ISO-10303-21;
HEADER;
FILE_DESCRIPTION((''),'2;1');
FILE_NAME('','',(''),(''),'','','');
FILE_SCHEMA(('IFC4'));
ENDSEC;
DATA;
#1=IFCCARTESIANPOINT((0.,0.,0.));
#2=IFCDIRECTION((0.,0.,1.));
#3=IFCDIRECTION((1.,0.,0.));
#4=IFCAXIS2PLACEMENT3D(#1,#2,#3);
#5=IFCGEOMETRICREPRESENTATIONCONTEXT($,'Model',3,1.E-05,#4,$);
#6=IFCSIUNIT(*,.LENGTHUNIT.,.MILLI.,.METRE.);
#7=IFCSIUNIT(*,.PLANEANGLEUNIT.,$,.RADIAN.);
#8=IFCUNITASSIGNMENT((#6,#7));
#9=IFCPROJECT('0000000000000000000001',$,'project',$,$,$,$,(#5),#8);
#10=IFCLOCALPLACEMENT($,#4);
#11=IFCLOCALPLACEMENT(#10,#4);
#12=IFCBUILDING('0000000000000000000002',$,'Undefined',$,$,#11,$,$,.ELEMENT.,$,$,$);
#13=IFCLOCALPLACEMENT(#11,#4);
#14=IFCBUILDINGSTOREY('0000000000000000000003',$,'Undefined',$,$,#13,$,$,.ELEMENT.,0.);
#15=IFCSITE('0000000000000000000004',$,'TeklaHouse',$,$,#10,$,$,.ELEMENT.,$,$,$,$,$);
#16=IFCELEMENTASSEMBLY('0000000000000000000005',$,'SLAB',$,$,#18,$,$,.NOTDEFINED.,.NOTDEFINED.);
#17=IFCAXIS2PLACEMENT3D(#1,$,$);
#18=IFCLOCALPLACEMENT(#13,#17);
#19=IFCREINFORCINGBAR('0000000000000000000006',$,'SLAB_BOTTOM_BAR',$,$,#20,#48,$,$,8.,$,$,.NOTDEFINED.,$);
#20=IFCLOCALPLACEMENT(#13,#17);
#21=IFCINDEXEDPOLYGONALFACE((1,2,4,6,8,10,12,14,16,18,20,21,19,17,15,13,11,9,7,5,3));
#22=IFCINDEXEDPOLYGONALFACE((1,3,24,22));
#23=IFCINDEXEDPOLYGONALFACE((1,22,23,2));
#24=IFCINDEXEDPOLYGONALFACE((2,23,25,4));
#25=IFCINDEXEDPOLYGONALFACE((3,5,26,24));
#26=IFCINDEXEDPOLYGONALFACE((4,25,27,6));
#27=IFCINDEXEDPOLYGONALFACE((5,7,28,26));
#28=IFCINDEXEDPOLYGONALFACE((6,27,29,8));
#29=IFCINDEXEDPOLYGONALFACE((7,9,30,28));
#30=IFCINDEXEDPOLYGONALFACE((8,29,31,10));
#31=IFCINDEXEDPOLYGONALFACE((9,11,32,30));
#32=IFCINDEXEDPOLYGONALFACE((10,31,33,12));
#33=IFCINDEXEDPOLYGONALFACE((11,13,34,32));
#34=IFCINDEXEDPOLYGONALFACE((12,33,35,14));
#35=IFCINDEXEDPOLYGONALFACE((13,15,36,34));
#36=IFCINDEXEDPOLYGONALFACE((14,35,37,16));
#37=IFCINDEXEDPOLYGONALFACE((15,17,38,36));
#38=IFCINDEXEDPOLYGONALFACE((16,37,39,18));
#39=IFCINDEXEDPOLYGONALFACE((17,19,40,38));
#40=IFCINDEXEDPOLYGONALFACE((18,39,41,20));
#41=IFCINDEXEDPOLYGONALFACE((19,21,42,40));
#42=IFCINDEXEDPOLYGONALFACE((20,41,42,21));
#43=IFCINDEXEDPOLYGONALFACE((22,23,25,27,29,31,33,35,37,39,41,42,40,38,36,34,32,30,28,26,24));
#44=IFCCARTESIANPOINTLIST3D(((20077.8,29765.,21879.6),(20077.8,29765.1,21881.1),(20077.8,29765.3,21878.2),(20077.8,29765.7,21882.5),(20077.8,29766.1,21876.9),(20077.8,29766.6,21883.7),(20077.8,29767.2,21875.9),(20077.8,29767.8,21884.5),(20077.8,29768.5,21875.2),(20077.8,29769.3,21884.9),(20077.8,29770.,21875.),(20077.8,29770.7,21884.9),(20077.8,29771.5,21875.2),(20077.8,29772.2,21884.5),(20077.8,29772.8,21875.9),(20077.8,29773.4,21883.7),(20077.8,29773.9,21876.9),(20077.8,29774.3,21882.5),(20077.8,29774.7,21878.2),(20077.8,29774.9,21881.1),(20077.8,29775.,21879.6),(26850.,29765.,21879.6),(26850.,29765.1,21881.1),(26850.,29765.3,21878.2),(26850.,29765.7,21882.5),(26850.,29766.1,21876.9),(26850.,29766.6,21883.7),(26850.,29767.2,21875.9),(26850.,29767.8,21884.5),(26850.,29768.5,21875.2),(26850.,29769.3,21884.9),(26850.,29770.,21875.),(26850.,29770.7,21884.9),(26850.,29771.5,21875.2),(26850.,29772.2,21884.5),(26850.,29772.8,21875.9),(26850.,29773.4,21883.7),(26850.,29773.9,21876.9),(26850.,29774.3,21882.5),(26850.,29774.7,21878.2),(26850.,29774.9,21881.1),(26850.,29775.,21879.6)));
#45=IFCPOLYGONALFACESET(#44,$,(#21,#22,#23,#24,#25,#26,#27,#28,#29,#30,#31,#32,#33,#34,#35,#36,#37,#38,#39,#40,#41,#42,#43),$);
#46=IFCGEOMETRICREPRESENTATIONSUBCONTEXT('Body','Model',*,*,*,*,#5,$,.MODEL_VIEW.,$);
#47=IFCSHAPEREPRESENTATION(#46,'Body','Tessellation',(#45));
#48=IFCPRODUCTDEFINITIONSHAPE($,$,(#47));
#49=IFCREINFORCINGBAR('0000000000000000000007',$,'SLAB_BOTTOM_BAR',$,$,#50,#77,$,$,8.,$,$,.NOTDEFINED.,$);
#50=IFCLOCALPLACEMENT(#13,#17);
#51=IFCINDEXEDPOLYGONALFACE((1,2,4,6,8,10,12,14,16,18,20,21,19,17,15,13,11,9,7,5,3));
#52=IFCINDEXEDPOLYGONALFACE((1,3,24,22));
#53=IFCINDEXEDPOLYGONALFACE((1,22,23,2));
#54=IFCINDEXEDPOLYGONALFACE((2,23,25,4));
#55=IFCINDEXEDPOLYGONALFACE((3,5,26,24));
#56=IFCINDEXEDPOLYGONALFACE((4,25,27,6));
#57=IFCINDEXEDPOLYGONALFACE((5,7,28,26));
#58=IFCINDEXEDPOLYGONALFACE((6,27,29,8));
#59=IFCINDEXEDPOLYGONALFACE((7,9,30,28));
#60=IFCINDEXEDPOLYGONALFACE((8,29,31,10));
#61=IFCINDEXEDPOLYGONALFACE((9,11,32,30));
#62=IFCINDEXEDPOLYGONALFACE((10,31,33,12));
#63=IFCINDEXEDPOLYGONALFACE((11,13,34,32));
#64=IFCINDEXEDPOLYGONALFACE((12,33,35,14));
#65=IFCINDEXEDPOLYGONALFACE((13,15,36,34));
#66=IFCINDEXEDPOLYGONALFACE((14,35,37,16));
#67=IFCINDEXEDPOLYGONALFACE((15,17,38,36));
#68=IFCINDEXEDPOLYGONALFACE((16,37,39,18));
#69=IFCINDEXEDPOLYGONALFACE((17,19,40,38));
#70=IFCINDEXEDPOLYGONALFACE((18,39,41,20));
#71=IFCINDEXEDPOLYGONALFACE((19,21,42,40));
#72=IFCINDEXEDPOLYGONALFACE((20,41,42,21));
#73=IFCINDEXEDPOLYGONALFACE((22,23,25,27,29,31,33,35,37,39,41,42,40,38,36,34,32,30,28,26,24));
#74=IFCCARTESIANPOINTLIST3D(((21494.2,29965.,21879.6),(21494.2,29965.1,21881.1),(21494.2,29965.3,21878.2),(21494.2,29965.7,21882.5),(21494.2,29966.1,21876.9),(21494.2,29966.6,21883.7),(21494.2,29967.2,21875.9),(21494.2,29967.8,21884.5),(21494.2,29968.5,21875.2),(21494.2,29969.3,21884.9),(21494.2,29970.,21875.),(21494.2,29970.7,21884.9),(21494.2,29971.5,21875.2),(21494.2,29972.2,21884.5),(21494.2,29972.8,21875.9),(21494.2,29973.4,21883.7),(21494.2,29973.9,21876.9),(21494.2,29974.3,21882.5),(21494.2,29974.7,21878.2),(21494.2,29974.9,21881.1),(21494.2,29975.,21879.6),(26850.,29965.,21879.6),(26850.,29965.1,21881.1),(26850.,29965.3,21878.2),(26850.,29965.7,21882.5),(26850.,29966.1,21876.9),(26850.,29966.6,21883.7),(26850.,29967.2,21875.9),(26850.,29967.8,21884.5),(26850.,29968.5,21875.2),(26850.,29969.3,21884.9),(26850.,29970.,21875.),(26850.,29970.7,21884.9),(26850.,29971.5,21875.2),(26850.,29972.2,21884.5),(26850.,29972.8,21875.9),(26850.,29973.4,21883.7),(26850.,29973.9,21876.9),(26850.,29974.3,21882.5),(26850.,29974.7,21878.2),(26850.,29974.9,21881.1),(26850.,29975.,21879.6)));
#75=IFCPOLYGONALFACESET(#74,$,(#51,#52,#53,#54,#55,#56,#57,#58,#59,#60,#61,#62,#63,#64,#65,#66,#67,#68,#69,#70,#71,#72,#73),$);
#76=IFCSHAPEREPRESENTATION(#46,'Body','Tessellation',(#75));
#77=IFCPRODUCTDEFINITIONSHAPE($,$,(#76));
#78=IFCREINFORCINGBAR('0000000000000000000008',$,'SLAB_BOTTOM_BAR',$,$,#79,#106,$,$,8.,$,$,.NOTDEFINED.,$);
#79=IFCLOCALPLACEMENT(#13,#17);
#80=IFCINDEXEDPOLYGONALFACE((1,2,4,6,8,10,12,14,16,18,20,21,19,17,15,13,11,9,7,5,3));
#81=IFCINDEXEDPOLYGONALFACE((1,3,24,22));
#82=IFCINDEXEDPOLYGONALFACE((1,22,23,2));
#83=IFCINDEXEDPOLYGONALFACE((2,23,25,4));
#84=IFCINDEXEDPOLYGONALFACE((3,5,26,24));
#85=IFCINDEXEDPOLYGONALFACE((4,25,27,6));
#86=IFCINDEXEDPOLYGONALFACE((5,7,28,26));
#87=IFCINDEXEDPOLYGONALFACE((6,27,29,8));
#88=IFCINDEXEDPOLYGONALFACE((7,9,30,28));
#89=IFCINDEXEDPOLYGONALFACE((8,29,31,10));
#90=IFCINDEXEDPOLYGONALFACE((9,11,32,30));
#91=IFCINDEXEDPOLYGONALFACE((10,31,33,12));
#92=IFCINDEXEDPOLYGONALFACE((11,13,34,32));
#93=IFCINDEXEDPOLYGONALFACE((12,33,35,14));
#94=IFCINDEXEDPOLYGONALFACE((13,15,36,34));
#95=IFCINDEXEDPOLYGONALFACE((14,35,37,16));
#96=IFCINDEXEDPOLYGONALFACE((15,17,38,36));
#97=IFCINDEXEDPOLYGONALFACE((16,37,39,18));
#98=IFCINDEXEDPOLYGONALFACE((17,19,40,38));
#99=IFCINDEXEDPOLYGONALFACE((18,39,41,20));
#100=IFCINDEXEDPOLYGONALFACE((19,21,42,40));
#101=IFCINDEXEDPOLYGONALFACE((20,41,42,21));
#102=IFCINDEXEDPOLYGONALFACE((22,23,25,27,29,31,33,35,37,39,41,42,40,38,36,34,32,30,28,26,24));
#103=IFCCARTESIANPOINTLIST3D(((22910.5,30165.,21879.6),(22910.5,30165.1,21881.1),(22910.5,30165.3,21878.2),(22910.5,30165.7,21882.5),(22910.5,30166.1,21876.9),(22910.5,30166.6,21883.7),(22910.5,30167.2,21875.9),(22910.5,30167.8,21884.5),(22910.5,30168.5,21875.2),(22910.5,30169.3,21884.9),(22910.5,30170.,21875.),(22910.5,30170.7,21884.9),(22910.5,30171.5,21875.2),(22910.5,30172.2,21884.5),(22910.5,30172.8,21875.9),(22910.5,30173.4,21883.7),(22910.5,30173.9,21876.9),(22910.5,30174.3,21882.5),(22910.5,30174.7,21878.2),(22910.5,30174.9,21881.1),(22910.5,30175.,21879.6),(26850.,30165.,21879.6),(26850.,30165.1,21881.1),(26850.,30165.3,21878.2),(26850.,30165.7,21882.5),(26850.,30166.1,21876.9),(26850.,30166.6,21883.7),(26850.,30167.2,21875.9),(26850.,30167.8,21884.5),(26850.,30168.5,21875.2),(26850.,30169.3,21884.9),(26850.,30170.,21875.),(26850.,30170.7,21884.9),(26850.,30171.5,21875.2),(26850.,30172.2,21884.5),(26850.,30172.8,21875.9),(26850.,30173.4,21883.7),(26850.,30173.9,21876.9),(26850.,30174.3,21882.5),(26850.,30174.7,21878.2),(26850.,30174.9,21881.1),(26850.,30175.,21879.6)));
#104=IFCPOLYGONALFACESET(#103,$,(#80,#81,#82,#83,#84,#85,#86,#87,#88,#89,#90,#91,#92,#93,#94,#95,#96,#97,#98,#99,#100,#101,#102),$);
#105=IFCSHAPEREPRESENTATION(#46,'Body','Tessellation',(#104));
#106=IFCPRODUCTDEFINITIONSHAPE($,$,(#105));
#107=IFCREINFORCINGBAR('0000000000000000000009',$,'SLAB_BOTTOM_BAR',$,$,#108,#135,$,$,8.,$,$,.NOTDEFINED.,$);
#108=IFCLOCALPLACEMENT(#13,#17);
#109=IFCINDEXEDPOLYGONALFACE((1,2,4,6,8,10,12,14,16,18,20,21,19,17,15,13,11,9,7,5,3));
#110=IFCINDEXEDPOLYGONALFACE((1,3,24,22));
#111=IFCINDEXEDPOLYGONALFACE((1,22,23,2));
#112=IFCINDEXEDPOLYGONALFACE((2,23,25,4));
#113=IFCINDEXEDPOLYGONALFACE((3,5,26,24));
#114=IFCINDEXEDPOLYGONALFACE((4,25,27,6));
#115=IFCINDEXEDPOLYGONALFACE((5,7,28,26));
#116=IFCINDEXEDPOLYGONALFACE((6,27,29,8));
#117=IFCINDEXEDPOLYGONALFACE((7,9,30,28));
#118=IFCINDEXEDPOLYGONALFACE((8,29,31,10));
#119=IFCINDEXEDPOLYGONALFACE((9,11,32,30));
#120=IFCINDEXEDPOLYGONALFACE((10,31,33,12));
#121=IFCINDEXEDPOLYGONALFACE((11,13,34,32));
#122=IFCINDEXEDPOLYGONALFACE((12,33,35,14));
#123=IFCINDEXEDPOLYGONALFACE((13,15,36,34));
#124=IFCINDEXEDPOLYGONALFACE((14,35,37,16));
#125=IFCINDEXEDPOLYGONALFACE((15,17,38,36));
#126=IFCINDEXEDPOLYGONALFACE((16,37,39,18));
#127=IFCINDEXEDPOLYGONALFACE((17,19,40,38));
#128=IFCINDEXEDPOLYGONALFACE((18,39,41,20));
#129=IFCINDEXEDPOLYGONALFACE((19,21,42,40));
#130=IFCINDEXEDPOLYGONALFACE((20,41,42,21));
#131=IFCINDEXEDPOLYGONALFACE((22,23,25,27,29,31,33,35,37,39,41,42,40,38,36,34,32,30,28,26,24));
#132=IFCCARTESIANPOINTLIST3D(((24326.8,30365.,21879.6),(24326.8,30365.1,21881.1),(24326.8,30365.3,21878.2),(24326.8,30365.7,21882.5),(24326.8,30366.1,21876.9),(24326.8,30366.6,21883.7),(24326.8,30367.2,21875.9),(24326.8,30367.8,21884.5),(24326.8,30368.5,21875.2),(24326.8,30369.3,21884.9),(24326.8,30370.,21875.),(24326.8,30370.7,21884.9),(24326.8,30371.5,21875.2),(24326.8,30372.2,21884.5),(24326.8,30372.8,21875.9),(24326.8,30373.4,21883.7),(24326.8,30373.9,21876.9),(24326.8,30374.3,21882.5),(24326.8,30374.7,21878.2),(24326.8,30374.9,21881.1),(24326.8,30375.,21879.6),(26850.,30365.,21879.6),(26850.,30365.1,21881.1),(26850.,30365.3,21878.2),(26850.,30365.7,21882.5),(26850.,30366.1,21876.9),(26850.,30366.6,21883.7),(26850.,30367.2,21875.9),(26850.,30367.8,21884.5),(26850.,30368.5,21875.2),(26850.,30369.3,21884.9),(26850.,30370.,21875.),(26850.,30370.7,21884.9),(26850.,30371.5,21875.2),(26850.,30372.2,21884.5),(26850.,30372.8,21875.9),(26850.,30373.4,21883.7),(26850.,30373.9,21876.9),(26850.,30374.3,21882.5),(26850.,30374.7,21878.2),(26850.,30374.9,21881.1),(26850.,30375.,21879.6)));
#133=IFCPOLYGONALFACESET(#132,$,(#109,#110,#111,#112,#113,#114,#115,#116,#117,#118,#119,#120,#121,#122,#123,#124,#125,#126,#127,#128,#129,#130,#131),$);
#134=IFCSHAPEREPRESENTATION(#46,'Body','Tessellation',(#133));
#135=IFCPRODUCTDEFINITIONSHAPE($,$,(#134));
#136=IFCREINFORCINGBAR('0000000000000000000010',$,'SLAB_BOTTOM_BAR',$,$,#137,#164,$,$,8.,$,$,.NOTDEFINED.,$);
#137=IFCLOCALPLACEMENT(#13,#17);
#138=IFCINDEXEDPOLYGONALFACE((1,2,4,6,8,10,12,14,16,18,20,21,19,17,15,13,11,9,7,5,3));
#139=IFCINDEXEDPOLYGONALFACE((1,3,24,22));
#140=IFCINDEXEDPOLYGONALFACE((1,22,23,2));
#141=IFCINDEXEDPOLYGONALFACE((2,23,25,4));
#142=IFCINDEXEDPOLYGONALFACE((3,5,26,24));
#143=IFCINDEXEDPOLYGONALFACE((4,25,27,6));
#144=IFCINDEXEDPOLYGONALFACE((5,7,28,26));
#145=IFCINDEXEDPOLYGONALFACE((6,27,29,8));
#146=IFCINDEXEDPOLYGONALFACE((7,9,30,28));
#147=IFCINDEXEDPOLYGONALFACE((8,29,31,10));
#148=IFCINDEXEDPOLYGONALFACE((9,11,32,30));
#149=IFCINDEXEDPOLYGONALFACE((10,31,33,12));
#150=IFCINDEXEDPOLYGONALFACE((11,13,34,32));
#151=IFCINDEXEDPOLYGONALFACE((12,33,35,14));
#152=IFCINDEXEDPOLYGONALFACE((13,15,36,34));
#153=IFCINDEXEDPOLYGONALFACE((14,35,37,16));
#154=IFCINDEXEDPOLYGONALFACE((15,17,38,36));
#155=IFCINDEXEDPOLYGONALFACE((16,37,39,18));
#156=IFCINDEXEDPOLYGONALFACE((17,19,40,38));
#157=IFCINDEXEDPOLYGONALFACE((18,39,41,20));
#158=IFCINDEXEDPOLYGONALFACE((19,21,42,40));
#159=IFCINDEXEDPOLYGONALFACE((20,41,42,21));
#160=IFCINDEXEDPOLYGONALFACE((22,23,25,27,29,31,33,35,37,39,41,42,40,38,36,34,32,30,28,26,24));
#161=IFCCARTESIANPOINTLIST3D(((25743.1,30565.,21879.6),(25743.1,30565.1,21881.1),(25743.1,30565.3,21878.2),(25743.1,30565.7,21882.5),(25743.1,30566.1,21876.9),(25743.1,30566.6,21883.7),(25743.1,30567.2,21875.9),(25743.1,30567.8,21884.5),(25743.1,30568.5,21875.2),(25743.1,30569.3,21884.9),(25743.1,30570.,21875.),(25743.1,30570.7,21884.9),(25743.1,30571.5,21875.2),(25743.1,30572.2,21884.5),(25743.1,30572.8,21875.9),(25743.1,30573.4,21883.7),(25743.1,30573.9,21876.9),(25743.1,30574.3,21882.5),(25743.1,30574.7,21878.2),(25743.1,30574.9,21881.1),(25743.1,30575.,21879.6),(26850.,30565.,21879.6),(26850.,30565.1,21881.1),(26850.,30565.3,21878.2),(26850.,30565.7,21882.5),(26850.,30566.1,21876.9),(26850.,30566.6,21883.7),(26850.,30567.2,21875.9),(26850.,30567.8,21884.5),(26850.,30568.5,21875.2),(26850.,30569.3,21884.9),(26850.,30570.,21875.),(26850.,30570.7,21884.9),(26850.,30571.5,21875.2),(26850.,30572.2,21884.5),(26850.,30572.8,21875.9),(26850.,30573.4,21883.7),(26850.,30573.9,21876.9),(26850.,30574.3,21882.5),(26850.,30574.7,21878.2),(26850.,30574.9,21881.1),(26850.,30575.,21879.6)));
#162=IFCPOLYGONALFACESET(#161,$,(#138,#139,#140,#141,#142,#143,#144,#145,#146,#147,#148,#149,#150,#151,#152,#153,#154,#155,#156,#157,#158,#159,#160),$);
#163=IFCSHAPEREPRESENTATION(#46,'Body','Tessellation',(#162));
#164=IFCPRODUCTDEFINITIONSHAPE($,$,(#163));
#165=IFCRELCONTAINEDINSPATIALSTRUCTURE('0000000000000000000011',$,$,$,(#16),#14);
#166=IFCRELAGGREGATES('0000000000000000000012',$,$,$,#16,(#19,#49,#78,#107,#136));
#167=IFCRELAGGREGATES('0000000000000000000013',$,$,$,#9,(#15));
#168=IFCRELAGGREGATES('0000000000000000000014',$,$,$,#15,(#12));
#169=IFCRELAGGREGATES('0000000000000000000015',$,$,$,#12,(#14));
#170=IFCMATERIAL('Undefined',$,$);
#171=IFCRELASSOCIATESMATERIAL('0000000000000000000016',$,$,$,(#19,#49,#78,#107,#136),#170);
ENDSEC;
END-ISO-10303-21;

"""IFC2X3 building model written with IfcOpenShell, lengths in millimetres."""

from ifc_helpers import new_model, entity, si_unit, frame, origin_with_axes, place, context, subcontext, project, spatial, source, transform, mapped, material, element, aggregate, save


model = new_model("IFC2X3")

# Units and contexts
model_context = context("Model", 3, precision=1e-05, world=origin_with_axes())
body_context = subcontext(model_context, "Body", "Model", "MODEL_VIEW")
ifc_project = project(units=[si_unit("LENGTHUNIT", "METRE", prefix="MILLI"), si_unit("PLANEANGLEUNIT", "RADIAN")], contexts=[model_context])

# Site, building, storey
site_placement = place(None, origin_with_axes())
site = spatial("IfcSite", under=ifc_project, at=site_placement, Name="TeklaHouse", CompositionType="ELEMENT")
building_placement = place(site_placement, origin_with_axes())
building = spatial("IfcBuilding", under=site, at=building_placement, Name="Undefined", CompositionType="ELEMENT")
storey_placement = place(building_placement, origin_with_axes())
storey = spatial("IfcBuildingStorey", under=building, at=storey_placement, Name="Undefined", CompositionType="ELEMENT", Elevation=0.0)

# Element assembly, reinforcing bars
assembly_1_placement = place(storey_placement, origin_with_axes())
assembly_1 = element("IfcElementAssembly", 1, at=assembly_1_placement, inside=storey, Name="SLAB", AssemblyPlace="NOTDEFINED", PredefinedType="NOTDEFINED")
ifc_material_1 = material(Name="Undefined")
shared_shape_1 = source(origin_with_axes(), body_context, "Body", "AdvancedSweptSolid", [
    entity("IfcSweptDiskSolid", entity("IfcTrimmedCurve", entity("IfcLine", entity("IfcCartesianPoint", [0.0, 0.0, 0.0]), entity("IfcVector", entity("IfcDirection", [1.0, 0.0, 0.0]), 1.0)), [entity("IfcParameterValue", 0.0)], [entity("IfcParameterValue", 6772.164192)], True, "PARAMETER"), 5.0, None, 0.0, 6772.2),
])
reinforcing_bar_1_placement = place(assembly_1_placement, frame((26850.0, 29770.0, 21880.0), z_axis=(0.0, 0.0, -1.0), x_axis=(-1.0, 0.0, 0.0)))
reinforcing_bar_1 = element("IfcReinforcingBar", 2, at=reinforcing_bar_1_placement, material=ifc_material_1, Name="SLAB_BOTTOM_BAR", BarRole="NOTDEFINED", NominalDiameter=8.0, context=body_context, shape_type="MappedRepresentation", body=[
    mapped(shared_shape_1, transform((0.0, 0.0, 0.0))),
])
shared_shape_2 = source(origin_with_axes(), body_context, "Body", "AdvancedSweptSolid", [
    entity("IfcSweptDiskSolid", entity("IfcTrimmedCurve", entity("IfcLine", entity("IfcCartesianPoint", [0.0, 0.0, 0.0]), entity("IfcVector", entity("IfcDirection", [1.0, 0.0, 0.0]), 1.0)), [entity("IfcParameterValue", 0.0)], [entity("IfcParameterValue", 5355.839456)], True, "PARAMETER"), 5.0, None, 0.0, 5355.8),
])
reinforcing_bar_2_placement = place(assembly_1_placement, frame((26850.0, 29970.0, 21880.0), z_axis=(0.0, 0.0, -1.0), x_axis=(-1.0, 0.0, 0.0)))
reinforcing_bar_2 = element("IfcReinforcingBar", 3, at=reinforcing_bar_2_placement, material=ifc_material_1, Name="SLAB_BOTTOM_BAR", BarRole="NOTDEFINED", NominalDiameter=8.0, context=body_context, shape_type="MappedRepresentation", body=[
    mapped(shared_shape_2, transform((0.0, 0.0, 0.0))),
])
shared_shape_3 = source(origin_with_axes(), body_context, "Body", "AdvancedSweptSolid", [
    entity("IfcSweptDiskSolid", entity("IfcTrimmedCurve", entity("IfcLine", entity("IfcCartesianPoint", [0.0, 0.0, 0.0]), entity("IfcVector", entity("IfcDirection", [1.0, 0.0, 0.0]), 1.0)), [entity("IfcParameterValue", 0.0)], [entity("IfcParameterValue", 3939.51472)], True, "PARAMETER"), 5.0, None, 0.0, 3939.5),
])
reinforcing_bar_3_placement = place(assembly_1_placement, frame((26850.0, 30170.0, 21880.0), z_axis=(0.0, 0.0, -1.0), x_axis=(-1.0, 0.0, 0.0)))
reinforcing_bar_3 = element("IfcReinforcingBar", 4, at=reinforcing_bar_3_placement, material=ifc_material_1, Name="SLAB_BOTTOM_BAR", BarRole="NOTDEFINED", NominalDiameter=8.0, context=body_context, shape_type="MappedRepresentation", body=[
    mapped(shared_shape_3, transform((0.0, 0.0, 0.0))),
])
shared_shape_4 = source(origin_with_axes(), body_context, "Body", "AdvancedSweptSolid", [
    entity("IfcSweptDiskSolid", entity("IfcTrimmedCurve", entity("IfcLine", entity("IfcCartesianPoint", [0.0, 0.0, 0.0]), entity("IfcVector", entity("IfcDirection", [1.0, 0.0, 0.0]), 1.0)), [entity("IfcParameterValue", 0.0)], [entity("IfcParameterValue", 2523.189984)], True, "PARAMETER"), 5.0, None, 0.0, 2523.2),
])
reinforcing_bar_4_placement = place(assembly_1_placement, frame((26850.0, 30370.0, 21880.0), z_axis=(0.0, 0.0, -1.0), x_axis=(-1.0, 0.0, 0.0)))
reinforcing_bar_4 = element("IfcReinforcingBar", 5, at=reinforcing_bar_4_placement, material=ifc_material_1, Name="SLAB_BOTTOM_BAR", BarRole="NOTDEFINED", NominalDiameter=8.0, context=body_context, shape_type="MappedRepresentation", body=[
    mapped(shared_shape_4, transform((0.0, 0.0, 0.0))),
])
shared_shape_5 = source(origin_with_axes(), body_context, "Body", "AdvancedSweptSolid", [
    entity("IfcSweptDiskSolid", entity("IfcTrimmedCurve", entity("IfcLine", entity("IfcCartesianPoint", [0.0, 0.0, 0.0]), entity("IfcVector", entity("IfcDirection", [1.0, 0.0, 0.0]), 1.0)), [entity("IfcParameterValue", 0.0)], [entity("IfcParameterValue", 1106.865248)], True, "PARAMETER"), 5.0, None, 0.0, 1106.9),
])
reinforcing_bar_5_placement = place(assembly_1_placement, frame((26850.0, 30570.0, 21880.0), z_axis=(0.0, 0.0, -1.0), x_axis=(-1.0, 0.0, 0.0)))
reinforcing_bar_5 = element("IfcReinforcingBar", 6, at=reinforcing_bar_5_placement, material=ifc_material_1, Name="SLAB_BOTTOM_BAR", BarRole="NOTDEFINED", NominalDiameter=8.0, context=body_context, shape_type="MappedRepresentation", body=[
    mapped(shared_shape_5, transform((0.0, 0.0, 0.0))),
])
aggregate(assembly_1, [reinforcing_bar_1, reinforcing_bar_2, reinforcing_bar_3, reinforcing_bar_4, reinforcing_bar_5])

save(model, "model.ifc")
